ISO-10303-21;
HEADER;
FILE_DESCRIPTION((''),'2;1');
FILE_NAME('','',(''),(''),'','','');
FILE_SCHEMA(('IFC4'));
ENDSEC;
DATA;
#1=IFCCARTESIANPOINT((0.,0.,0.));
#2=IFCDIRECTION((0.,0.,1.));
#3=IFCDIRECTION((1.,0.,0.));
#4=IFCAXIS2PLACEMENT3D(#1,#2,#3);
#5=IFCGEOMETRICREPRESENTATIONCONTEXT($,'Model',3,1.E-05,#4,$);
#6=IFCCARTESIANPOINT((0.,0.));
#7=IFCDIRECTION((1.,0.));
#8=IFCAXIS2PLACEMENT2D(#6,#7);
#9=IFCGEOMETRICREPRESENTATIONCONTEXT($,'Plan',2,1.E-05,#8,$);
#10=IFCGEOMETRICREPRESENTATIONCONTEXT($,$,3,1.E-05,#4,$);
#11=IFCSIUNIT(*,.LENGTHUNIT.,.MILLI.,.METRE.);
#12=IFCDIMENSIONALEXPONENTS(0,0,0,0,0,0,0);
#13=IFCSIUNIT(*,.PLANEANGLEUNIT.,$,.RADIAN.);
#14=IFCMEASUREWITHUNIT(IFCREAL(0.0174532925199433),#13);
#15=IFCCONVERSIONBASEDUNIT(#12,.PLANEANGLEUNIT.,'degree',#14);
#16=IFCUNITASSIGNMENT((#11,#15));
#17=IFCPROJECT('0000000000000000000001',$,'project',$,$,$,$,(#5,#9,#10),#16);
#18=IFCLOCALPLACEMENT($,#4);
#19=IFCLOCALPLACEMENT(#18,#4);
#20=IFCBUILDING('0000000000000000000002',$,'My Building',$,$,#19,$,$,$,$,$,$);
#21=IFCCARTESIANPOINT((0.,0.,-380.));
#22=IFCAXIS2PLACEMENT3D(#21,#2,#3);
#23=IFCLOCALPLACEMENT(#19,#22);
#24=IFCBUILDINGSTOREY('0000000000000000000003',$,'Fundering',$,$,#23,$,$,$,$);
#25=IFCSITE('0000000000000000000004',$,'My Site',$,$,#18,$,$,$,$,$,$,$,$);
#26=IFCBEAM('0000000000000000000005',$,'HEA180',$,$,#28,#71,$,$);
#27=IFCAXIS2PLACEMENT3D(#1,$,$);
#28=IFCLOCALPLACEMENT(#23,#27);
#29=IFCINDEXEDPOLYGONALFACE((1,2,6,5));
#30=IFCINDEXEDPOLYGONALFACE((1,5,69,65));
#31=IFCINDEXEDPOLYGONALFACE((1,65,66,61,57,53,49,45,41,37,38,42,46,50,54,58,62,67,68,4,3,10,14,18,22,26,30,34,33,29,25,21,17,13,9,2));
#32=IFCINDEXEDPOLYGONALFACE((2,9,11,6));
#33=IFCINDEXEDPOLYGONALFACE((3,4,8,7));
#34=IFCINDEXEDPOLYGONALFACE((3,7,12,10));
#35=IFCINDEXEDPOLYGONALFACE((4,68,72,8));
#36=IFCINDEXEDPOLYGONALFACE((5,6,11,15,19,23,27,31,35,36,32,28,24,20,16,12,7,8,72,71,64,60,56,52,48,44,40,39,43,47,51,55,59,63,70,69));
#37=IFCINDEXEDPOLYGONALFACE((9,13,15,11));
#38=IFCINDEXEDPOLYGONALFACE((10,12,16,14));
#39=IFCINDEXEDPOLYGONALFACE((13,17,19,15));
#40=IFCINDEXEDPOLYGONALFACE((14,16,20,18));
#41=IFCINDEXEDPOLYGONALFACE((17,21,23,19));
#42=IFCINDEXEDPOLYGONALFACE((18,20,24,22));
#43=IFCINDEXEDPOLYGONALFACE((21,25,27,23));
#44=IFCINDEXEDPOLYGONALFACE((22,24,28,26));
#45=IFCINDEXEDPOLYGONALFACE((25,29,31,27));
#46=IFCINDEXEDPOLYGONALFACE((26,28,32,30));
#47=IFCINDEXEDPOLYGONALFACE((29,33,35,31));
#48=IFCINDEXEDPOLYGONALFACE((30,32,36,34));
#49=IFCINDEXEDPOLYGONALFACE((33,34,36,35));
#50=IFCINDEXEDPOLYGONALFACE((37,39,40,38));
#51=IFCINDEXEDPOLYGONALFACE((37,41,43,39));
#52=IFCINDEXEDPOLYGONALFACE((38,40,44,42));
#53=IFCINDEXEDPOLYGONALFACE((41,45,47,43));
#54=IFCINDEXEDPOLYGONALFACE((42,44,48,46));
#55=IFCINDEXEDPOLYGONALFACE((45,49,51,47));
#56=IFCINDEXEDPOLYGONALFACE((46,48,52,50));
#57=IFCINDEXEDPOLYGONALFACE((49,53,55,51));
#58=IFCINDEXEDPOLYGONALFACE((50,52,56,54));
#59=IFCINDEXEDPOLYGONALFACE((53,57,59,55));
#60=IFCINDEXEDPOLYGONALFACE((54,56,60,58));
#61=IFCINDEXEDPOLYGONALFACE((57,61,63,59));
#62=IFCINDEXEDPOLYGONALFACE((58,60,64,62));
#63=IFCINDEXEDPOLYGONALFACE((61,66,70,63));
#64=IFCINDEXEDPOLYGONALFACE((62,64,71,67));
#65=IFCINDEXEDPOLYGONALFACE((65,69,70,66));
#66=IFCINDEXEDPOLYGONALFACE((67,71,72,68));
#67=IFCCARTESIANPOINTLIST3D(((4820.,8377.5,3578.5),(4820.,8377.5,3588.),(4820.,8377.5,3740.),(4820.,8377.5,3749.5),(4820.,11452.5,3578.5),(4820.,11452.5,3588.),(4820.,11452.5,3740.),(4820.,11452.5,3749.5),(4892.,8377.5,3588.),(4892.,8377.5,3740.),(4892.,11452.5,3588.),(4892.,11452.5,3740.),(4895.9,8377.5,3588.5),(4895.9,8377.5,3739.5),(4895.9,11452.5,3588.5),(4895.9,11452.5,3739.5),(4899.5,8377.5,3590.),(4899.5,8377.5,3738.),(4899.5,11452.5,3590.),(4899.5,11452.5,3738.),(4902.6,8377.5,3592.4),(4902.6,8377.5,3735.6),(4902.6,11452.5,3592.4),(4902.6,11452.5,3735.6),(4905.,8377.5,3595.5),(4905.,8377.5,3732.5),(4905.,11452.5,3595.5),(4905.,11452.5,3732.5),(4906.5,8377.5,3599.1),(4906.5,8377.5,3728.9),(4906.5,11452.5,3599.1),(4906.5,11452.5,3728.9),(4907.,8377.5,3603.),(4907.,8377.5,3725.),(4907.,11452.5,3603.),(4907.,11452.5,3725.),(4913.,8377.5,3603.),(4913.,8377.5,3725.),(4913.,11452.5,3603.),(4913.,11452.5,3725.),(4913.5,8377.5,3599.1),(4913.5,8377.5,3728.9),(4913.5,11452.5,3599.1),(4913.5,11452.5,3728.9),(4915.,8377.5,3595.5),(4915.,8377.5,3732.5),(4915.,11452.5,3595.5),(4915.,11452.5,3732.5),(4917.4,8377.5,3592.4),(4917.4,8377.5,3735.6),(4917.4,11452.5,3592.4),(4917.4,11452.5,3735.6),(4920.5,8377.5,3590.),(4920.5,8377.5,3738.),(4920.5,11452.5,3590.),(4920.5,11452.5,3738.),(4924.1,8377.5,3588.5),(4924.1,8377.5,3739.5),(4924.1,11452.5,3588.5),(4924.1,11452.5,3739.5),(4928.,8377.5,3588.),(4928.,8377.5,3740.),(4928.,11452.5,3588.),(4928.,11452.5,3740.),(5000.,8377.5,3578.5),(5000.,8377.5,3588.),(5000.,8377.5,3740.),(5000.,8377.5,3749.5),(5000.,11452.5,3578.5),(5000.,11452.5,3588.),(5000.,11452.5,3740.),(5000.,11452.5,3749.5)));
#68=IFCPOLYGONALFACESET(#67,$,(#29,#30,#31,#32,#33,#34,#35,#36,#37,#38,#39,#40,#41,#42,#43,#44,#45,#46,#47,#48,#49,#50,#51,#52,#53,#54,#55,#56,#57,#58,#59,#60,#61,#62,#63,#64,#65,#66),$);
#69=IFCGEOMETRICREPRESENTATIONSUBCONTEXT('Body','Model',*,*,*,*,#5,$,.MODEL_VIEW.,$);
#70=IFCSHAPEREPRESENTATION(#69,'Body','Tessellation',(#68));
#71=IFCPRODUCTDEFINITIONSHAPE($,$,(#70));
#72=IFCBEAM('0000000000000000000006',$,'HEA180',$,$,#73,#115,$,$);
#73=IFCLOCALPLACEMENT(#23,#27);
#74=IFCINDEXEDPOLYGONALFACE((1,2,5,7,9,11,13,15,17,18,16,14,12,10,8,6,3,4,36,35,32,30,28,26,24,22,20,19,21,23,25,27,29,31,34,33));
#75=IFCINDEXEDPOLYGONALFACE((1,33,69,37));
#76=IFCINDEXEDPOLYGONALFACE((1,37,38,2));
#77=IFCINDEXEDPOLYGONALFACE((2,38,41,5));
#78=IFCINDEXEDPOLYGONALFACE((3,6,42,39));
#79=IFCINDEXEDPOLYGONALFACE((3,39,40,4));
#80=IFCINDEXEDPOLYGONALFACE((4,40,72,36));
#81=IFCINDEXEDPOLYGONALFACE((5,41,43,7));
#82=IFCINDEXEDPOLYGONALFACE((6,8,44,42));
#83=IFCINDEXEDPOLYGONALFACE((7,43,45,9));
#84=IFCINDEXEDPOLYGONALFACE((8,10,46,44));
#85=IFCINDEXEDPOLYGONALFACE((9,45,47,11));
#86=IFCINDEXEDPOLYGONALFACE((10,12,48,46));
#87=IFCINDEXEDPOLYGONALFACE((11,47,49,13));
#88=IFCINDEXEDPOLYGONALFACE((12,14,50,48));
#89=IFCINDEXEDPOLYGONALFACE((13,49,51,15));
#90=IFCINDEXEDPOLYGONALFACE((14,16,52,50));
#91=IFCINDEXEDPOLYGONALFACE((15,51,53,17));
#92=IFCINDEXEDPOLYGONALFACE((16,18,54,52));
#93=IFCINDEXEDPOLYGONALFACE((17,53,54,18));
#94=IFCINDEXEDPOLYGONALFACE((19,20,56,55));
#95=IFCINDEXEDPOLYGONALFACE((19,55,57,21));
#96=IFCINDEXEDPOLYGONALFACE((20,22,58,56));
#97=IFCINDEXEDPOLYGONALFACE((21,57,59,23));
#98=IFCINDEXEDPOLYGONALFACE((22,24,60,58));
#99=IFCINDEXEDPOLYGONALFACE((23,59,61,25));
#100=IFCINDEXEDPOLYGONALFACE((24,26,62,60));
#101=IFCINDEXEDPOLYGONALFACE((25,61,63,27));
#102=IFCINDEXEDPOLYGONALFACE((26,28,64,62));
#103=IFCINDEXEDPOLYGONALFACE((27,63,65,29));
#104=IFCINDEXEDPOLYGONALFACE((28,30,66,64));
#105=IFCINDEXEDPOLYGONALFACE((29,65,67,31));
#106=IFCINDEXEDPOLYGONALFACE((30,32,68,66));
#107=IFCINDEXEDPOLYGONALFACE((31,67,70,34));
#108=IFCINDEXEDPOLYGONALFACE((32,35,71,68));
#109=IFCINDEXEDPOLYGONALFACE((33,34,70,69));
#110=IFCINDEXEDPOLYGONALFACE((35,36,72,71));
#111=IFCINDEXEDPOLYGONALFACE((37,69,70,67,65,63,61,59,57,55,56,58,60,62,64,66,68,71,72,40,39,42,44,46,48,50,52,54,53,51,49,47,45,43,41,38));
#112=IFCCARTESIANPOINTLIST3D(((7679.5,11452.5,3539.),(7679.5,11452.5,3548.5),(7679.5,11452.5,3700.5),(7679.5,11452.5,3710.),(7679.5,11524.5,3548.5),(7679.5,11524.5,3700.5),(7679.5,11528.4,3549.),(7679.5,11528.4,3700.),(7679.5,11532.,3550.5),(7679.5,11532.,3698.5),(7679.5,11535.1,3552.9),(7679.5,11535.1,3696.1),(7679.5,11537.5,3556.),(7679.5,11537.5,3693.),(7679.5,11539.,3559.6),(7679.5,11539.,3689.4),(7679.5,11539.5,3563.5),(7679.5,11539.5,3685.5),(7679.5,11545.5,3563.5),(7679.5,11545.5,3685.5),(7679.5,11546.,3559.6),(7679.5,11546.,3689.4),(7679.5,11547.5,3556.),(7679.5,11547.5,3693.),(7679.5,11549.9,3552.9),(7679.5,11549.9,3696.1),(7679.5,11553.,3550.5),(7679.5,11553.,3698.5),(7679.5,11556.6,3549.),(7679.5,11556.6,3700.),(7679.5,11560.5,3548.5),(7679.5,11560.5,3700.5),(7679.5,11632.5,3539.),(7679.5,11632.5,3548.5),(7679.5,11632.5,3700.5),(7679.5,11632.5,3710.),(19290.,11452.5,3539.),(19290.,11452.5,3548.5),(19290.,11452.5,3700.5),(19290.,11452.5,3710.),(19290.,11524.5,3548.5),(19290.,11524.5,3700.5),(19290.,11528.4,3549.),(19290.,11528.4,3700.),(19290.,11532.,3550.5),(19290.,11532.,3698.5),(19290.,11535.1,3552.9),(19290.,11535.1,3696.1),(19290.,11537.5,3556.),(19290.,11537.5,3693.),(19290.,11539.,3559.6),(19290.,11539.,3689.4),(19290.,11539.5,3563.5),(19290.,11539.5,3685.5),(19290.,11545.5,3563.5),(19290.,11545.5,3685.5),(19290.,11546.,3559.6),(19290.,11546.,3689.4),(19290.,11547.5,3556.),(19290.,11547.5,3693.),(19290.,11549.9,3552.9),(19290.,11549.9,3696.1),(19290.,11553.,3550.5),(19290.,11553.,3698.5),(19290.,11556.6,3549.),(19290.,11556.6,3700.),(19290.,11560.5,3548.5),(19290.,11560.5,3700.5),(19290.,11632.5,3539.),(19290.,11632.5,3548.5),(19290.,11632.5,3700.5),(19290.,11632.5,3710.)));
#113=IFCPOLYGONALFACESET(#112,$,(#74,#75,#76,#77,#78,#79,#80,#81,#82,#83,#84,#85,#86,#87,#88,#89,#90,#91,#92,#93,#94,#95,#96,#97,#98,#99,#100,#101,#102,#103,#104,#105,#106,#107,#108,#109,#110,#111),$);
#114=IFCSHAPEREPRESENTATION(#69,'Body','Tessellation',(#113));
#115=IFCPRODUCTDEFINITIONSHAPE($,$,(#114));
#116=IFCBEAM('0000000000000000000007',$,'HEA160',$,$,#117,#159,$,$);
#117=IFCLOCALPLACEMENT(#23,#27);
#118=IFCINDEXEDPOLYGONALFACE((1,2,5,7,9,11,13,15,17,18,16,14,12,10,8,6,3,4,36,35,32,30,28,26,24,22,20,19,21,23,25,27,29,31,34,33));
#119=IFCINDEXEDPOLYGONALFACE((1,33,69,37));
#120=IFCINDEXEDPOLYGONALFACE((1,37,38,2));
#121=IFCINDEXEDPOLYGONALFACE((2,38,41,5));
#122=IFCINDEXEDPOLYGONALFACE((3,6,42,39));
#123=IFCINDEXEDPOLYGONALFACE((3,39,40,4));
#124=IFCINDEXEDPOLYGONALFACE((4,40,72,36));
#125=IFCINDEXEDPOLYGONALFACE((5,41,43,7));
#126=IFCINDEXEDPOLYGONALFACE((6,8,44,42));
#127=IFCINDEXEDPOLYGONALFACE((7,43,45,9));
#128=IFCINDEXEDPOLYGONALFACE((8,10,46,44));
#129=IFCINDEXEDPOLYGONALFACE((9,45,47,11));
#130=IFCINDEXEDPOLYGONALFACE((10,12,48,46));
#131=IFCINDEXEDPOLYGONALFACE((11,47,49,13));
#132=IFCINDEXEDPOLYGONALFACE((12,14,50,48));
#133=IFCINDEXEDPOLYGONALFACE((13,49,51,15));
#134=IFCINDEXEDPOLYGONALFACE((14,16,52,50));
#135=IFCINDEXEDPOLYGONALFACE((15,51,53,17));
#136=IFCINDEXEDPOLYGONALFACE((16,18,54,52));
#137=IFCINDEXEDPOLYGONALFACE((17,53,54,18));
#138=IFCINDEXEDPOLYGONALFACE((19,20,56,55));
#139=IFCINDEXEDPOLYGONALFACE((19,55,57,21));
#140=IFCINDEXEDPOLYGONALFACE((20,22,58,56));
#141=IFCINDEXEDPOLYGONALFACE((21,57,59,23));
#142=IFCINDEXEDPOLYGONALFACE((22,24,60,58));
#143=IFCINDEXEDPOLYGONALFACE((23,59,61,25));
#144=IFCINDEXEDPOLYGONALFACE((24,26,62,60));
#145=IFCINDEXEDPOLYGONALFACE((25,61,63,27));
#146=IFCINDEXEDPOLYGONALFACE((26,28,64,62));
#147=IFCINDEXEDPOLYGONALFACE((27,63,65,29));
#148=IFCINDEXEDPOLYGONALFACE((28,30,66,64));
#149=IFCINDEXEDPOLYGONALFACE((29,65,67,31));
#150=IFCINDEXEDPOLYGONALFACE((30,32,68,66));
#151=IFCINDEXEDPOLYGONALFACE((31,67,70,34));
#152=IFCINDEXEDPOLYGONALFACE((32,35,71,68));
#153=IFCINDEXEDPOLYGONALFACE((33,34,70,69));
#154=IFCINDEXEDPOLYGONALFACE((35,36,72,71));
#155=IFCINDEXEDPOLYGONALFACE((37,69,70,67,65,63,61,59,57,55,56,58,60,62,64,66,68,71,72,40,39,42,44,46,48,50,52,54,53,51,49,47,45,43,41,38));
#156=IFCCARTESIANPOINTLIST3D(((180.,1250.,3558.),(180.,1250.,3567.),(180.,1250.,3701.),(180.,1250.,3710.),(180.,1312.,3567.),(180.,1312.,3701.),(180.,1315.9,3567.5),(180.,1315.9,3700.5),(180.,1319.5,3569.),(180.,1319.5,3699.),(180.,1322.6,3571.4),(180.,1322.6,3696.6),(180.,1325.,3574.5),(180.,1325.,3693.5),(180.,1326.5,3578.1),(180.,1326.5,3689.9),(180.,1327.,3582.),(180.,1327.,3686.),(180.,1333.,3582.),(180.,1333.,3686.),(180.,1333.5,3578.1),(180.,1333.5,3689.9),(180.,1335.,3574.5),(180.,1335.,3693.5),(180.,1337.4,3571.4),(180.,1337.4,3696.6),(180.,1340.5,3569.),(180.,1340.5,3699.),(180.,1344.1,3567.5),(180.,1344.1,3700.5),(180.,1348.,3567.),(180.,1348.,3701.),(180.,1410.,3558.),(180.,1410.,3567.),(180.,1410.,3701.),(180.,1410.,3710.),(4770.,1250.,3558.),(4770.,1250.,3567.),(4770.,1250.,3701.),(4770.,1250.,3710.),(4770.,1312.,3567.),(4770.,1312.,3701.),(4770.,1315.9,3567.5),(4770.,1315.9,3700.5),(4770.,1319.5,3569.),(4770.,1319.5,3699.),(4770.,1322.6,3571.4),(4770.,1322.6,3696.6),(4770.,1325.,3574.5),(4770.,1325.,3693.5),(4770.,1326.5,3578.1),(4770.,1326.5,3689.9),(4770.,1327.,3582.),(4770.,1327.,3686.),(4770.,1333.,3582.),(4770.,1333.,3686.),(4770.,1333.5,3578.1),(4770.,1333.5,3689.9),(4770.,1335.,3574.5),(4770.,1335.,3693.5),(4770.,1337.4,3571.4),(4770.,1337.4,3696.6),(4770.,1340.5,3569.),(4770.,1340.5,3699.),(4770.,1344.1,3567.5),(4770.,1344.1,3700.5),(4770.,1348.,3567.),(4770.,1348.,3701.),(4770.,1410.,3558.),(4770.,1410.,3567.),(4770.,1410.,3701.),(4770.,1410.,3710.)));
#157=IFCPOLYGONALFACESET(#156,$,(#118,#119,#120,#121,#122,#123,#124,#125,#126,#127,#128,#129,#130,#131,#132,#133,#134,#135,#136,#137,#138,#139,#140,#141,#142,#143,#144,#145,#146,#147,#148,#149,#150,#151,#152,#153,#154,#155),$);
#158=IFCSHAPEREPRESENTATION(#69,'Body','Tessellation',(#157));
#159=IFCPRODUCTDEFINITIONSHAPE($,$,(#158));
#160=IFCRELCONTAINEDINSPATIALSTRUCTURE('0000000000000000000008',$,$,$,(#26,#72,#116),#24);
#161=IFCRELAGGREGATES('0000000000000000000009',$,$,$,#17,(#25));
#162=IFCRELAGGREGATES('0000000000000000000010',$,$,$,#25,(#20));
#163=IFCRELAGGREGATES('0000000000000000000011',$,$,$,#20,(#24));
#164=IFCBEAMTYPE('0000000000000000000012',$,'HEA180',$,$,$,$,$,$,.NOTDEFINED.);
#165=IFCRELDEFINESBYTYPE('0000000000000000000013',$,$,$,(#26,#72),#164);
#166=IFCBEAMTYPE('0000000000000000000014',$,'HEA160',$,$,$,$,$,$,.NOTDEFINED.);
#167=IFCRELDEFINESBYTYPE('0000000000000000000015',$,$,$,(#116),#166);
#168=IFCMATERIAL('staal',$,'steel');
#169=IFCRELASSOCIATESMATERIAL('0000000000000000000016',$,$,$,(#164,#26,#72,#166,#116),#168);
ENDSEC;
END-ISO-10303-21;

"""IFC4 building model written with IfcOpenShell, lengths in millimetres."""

from ifc_helpers import new_model, entity, si_unit, converted_unit, frame, origin_with_axes, origin_2d_with_axis, place, context, subcontext, project, spatial, i_section, extrude, material, material_profile, profile_set, profile_usage, type_object, element, save


model = new_model("IFC4")

# Units and contexts
model_context = context("Model", 3, precision=1e-05, world=origin_with_axes())
plan_context = context("Plan", 2, precision=1e-05, world=origin_2d_with_axis())
context_of_model = context(None, 3, precision=1e-05, world=origin_with_axes())
body_context = subcontext(model_context, "Body", "Model", "MODEL_VIEW")
ifc_project = project(units=[si_unit("LENGTHUNIT", "METRE", prefix="MILLI"), converted_unit("PLANEANGLEUNIT", "degree", entity("IfcReal", 0.0174532925199433), si_unit("PLANEANGLEUNIT", "RADIAN"), dimensions=[0, 0, 0, 0, 0, 0, 0])], contexts=[model_context, plan_context, context_of_model])

# Site, building, storey
site_placement = place(None, origin_with_axes())
site = spatial("IfcSite", under=ifc_project, at=site_placement, Name="My Site")
building_placement = place(site_placement, origin_with_axes())
building = spatial("IfcBuilding", under=site, at=building_placement, Name="My Building")
storey_placement = place(building_placement, frame((0.0, 0.0, -380.0), z_axis=(0.0, 0.0, 1.0), x_axis=(1.0, 0.0, 0.0)))
storey = spatial("IfcBuildingStorey", under=building, at=storey_placement, Name="Fundering")

# Shared definitions
ifc_material_1 = material(Name="staal", Category="steel")

# Beams
ifc_material_profile_1 = material_profile(ifc_material_1, i_section(OverallWidth=180.0, OverallDepth=171.0, WebThickness=6.0, FlangeThickness=9.5, FilletRadius=15.0))
ifc_profile_set_1 = profile_set([ifc_material_profile_1], Name="HEA180")
beam_type_1 = type_object("IfcBeamType", Name="HEA180", PredefinedType="NOTDEFINED", material=ifc_profile_set_1)
ifc_profile_usage_1 = profile_usage(ifc_profile_set_1)
beam_1_placement = place(storey_placement, frame((4910.0, 8377.5, 3664.0), z_axis=(0.0, 1.0, 0.0), x_axis=(-1.0, 0.0, 0.0)))
element("IfcBeam", 1, at=beam_1_placement, inside=storey, type_object=beam_type_1, material=ifc_profile_usage_1, Name="HEA180", context=body_context, shape_type="SweptSolid", body=[
    extrude(i_section(OverallWidth=180.0, OverallDepth=171.0, WebThickness=6.0, FlangeThickness=9.5, FilletRadius=15.0), origin_with_axes(), (0.0, 0.0, 1.0), 3075.0),
])
ifc_profile_usage_2 = profile_usage(ifc_profile_set_1)
beam_2_placement = place(storey_placement, frame((7679.5, 11542.5, 3624.5), z_axis=(1.0, 0.0, 0.0), x_axis=(0.0, 1.0, 0.0)))
element("IfcBeam", 2, at=beam_2_placement, inside=storey, type_object=beam_type_1, material=ifc_profile_usage_2, Name="HEA180", context=body_context, shape_type="SweptSolid", body=[
    extrude(i_section(OverallWidth=180.0, OverallDepth=171.0, WebThickness=6.0, FlangeThickness=9.5, FilletRadius=15.0), origin_with_axes(), (0.0, 0.0, 1.0), 11610.5),
])
ifc_material_profile_2 = material_profile(ifc_material_1, i_section(OverallWidth=160.0, OverallDepth=152.0, WebThickness=6.0, FlangeThickness=9.0, FilletRadius=15.0))
ifc_profile_set_2 = profile_set([ifc_material_profile_2], Name="HEA160")
ifc_profile_usage_3 = profile_usage(ifc_profile_set_2, cardinal=5)
beam_type_2 = type_object("IfcBeamType", Name="HEA160", PredefinedType="NOTDEFINED", material=ifc_profile_set_2)
beam_3_placement = place(storey_placement, frame((180.0, 1330.0, 3634.0), z_axis=(1.0, 0.0, 0.0), x_axis=(0.0, 1.0, 0.0)))
element("IfcBeam", 3, at=beam_3_placement, inside=storey, type_object=beam_type_2, material=ifc_profile_usage_3, Name="HEA160", context=body_context, shape_type="SweptSolid", body=[
    extrude(i_section(OverallWidth=160.0, OverallDepth=152.0, WebThickness=6.0, FlangeThickness=9.0, FilletRadius=15.0), origin_with_axes(), (0.0, 0.0, 1.0), 4590.0),
])

save(model, "model.ifc")
